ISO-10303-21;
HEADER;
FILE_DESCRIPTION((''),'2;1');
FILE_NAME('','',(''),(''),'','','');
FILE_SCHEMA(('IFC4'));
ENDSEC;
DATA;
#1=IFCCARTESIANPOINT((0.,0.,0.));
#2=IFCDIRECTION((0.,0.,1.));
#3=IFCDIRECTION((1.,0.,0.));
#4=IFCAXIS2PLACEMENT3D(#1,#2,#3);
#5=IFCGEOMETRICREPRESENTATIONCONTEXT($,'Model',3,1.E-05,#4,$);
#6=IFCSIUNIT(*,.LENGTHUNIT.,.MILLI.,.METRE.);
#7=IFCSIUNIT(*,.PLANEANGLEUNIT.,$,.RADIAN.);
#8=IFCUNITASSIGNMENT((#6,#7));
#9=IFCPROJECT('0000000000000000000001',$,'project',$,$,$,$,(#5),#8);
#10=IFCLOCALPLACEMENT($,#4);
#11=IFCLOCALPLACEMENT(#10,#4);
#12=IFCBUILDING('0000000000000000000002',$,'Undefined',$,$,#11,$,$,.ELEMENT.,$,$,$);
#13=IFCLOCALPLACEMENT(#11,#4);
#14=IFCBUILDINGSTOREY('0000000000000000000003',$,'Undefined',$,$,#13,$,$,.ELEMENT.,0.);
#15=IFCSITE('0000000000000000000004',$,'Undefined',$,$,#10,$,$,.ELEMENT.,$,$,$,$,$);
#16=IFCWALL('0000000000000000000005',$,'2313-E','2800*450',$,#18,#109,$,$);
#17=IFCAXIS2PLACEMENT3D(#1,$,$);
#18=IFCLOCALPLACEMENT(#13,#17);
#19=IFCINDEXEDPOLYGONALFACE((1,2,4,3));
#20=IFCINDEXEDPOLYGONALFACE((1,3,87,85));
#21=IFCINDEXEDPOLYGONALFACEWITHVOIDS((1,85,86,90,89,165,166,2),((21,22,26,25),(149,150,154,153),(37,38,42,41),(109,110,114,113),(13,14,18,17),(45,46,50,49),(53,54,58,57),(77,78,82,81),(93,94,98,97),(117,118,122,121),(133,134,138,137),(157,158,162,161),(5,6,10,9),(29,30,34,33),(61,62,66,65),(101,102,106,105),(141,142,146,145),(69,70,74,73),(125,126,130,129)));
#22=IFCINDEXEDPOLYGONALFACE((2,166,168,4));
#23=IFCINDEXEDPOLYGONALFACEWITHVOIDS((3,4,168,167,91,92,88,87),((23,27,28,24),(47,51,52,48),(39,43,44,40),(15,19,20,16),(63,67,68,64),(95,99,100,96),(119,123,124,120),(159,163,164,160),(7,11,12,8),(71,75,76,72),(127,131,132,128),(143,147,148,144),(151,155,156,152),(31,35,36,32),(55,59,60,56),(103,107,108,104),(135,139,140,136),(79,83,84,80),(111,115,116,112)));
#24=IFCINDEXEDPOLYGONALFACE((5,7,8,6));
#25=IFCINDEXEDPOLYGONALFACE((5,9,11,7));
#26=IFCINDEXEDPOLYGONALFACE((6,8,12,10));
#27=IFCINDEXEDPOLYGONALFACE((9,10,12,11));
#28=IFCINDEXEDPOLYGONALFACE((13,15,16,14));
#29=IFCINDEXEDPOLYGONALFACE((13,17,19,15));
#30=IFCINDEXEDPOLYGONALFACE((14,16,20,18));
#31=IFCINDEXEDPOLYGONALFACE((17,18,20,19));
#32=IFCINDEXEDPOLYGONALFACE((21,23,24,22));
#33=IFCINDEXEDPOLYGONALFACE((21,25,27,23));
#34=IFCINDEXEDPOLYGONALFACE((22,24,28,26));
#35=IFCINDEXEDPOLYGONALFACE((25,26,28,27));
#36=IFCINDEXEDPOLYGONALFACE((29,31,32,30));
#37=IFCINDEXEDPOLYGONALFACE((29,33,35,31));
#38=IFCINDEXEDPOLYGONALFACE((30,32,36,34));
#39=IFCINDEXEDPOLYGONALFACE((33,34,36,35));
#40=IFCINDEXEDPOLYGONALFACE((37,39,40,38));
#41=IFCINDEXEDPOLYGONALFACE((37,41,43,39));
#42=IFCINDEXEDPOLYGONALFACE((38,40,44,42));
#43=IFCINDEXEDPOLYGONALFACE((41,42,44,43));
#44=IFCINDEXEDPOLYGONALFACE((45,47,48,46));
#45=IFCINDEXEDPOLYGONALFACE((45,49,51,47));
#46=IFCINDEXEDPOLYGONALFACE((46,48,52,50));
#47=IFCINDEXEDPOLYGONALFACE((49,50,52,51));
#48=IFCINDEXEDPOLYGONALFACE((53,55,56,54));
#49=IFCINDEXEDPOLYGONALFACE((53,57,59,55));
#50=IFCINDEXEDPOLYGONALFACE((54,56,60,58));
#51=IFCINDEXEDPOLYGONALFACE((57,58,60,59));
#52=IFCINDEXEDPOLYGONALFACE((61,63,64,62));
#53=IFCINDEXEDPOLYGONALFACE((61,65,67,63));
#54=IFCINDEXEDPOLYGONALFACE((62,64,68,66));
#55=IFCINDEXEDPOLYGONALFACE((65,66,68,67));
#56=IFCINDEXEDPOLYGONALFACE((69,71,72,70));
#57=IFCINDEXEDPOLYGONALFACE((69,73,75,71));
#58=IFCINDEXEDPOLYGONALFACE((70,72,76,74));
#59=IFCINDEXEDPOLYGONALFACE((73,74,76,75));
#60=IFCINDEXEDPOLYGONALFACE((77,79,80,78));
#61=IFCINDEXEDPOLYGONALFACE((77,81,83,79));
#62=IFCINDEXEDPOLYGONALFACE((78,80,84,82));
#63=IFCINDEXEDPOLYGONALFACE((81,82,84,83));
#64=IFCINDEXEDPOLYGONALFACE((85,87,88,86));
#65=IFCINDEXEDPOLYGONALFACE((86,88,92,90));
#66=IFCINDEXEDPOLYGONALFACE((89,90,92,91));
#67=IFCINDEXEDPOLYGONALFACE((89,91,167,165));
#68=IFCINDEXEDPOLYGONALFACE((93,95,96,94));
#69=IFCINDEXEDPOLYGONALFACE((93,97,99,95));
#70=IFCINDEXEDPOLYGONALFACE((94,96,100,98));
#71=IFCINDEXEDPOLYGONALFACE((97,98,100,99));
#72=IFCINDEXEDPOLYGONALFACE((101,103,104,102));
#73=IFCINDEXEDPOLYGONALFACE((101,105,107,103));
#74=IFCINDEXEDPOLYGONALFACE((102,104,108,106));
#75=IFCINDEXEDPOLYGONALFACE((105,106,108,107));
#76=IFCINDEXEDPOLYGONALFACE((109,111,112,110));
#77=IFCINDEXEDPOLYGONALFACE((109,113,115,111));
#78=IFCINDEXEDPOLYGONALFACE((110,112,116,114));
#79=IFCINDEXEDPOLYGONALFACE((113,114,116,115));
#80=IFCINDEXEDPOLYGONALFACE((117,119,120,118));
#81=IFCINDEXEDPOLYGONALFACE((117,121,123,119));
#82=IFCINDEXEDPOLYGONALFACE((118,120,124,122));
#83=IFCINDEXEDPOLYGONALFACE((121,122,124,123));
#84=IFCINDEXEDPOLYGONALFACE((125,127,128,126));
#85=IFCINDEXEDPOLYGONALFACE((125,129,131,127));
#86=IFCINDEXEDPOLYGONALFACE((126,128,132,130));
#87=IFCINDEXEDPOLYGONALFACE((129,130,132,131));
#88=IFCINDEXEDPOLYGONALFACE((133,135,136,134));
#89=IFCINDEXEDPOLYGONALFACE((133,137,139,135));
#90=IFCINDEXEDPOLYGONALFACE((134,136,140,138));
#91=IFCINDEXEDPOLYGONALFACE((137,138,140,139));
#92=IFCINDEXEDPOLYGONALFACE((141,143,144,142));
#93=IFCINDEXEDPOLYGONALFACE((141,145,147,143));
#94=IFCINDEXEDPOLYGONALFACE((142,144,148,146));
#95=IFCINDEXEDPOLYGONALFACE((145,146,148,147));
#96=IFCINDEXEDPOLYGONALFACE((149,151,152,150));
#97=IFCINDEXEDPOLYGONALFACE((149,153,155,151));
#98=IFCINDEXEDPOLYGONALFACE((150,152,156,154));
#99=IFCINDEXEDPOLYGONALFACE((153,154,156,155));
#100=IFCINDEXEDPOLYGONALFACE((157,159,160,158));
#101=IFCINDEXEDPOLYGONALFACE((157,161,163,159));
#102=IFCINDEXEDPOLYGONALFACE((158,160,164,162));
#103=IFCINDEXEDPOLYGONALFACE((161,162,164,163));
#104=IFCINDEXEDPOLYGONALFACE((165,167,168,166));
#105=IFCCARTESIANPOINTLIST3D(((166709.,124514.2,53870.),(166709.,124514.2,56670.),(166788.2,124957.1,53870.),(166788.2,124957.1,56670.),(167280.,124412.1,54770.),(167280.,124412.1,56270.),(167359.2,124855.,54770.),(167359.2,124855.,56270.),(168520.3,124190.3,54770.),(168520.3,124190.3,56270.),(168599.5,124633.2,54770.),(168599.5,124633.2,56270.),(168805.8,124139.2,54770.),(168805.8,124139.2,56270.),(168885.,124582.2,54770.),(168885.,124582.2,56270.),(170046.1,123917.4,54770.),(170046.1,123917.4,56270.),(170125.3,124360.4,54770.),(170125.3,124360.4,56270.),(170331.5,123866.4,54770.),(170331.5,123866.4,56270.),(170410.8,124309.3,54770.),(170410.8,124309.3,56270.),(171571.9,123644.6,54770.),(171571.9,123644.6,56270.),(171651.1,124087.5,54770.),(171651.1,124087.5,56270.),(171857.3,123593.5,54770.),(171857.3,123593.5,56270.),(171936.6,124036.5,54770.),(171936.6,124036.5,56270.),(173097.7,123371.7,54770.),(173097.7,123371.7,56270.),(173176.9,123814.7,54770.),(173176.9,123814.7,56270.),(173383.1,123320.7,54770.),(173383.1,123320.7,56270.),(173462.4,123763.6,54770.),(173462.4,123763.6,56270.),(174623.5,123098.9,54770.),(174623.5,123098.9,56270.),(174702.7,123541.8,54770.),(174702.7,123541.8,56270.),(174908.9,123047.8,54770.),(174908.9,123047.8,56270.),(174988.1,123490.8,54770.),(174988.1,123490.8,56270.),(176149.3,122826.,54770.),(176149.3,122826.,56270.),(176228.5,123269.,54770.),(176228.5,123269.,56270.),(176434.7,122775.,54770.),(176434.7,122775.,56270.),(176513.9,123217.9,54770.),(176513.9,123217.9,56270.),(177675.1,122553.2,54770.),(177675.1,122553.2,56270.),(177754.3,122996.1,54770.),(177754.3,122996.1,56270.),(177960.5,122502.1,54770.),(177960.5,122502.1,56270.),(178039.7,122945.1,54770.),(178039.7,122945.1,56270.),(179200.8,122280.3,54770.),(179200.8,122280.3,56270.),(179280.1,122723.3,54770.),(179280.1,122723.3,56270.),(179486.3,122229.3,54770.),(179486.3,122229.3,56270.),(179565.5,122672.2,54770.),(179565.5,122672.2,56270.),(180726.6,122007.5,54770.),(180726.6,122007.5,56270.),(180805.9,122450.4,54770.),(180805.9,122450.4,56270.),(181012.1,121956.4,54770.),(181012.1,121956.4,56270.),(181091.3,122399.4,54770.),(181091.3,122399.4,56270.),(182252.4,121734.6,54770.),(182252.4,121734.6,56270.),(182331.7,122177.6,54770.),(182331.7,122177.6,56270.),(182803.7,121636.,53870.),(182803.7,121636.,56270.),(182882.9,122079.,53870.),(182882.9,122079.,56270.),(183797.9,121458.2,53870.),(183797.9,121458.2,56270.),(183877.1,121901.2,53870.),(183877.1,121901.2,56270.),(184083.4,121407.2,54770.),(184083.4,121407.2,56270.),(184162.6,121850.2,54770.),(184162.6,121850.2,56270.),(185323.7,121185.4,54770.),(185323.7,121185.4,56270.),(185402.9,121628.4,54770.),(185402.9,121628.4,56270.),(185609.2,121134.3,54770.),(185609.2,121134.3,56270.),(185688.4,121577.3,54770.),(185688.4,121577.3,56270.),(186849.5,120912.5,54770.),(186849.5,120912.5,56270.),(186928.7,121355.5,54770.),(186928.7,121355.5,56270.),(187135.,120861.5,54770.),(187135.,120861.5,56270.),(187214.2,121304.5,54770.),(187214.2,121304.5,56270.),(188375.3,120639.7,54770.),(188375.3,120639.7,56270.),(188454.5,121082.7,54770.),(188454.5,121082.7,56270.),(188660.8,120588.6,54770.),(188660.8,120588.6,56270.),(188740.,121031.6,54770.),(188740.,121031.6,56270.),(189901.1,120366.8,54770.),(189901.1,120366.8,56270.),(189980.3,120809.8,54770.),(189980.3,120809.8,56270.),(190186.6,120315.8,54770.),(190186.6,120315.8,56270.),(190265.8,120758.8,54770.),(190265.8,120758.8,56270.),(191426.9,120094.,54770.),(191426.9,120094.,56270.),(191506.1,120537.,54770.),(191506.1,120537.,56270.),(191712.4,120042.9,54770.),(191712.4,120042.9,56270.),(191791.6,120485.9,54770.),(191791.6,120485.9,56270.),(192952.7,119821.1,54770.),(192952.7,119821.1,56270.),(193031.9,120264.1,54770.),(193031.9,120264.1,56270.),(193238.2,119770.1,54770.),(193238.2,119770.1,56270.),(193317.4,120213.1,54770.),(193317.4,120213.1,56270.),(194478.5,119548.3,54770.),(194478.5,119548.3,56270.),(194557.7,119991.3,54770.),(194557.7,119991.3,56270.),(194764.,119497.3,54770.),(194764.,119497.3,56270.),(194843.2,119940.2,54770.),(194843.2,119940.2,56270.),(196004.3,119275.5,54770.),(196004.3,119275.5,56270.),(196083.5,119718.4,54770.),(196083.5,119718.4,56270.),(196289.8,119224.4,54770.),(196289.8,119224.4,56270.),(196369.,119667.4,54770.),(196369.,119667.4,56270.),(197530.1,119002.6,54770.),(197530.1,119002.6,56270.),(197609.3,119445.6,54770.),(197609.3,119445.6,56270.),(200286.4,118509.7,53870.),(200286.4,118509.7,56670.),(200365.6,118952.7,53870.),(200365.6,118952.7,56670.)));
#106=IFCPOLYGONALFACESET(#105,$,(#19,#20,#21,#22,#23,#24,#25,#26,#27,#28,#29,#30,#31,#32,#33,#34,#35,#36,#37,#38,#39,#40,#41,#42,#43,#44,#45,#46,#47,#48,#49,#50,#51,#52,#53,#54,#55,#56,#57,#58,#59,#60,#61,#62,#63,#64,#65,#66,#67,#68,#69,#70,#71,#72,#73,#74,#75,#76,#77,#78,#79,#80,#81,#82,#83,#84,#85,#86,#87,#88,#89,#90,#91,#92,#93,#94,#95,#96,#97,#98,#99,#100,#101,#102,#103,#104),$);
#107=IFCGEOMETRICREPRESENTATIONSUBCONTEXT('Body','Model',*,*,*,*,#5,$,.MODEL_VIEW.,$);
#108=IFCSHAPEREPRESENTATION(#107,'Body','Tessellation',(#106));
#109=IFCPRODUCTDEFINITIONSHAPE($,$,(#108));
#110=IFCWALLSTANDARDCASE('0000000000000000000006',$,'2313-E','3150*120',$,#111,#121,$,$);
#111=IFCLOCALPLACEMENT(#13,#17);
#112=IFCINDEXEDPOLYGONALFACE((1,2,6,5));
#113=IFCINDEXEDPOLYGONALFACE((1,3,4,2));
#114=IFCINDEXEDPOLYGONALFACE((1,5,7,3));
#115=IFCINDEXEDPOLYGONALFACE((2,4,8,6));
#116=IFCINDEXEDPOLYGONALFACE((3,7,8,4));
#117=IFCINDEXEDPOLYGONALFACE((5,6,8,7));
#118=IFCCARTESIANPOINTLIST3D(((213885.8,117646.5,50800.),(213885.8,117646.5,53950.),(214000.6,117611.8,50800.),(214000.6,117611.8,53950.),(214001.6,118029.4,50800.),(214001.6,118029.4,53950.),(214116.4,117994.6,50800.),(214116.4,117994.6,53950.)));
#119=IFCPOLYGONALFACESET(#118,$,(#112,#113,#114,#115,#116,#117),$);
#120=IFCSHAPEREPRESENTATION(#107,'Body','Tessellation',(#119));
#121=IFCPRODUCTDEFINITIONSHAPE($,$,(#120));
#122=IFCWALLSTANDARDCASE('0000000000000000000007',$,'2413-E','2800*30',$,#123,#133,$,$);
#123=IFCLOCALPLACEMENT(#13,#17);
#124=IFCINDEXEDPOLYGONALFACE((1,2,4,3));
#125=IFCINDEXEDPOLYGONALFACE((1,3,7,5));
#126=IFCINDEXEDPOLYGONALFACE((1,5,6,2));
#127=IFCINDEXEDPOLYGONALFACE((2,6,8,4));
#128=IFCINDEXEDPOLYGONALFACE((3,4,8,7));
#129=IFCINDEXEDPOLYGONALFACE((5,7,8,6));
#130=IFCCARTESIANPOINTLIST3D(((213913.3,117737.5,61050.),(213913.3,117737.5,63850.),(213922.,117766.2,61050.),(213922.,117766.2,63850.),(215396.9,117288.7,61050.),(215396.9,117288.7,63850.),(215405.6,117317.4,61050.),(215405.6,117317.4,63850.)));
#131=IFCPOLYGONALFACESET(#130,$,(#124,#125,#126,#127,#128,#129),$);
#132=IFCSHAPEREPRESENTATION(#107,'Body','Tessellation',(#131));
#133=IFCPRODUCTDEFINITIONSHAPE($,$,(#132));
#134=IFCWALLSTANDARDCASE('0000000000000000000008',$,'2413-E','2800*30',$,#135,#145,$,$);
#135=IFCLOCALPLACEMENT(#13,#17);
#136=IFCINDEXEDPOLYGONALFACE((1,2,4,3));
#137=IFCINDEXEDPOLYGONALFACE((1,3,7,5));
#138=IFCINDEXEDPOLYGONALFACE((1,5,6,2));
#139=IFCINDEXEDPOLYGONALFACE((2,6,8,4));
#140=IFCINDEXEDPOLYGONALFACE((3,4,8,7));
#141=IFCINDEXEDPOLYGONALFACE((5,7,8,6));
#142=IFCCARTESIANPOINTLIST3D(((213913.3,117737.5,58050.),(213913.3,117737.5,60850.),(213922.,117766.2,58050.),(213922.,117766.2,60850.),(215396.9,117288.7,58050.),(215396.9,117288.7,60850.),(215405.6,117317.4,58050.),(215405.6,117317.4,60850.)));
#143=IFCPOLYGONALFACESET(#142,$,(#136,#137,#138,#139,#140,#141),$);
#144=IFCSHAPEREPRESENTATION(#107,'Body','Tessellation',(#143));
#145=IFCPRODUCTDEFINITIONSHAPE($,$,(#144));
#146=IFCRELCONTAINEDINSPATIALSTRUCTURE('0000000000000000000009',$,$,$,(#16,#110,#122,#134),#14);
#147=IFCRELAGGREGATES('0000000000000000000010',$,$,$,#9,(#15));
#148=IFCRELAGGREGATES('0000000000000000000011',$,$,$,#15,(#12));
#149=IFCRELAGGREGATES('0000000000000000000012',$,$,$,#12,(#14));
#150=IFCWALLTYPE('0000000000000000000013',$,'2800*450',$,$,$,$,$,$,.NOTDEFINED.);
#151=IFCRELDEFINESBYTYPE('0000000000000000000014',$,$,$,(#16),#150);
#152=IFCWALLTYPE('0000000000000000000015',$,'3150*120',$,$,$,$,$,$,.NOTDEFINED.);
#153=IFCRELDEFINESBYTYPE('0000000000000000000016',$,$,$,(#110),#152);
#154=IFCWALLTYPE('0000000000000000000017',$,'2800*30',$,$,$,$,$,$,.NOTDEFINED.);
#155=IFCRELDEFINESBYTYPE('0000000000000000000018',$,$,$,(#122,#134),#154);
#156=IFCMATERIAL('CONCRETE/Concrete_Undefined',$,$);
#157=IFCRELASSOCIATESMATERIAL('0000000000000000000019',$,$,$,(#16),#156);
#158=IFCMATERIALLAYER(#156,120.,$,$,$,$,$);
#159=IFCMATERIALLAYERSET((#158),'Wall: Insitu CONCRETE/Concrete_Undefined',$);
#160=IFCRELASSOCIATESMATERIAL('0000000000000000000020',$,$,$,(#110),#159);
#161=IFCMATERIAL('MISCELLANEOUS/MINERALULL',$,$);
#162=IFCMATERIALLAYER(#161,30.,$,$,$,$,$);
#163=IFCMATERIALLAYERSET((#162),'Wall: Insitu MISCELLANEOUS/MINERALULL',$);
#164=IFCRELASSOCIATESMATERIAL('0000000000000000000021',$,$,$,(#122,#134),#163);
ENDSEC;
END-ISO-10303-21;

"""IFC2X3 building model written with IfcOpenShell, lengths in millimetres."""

from ifc_helpers import new_model, si_unit, frame, frame_2d, origin_with_axes, place, context, subcontext, project, spatial, rectangle, extrude, boolean, material, layer, layer_set, layer_usage, type_object, element, save


model = new_model("IFC2X3")

# Units and contexts
model_context = context("Model", 3, precision=1e-05, world=origin_with_axes())
body_context = subcontext(model_context, "Body", "Model", "MODEL_VIEW")
ifc_project = project(units=[si_unit("LENGTHUNIT", "METRE", prefix="MILLI"), si_unit("PLANEANGLEUNIT", "RADIAN")], contexts=[model_context])

# Site, building, storey
site_placement = place(None, origin_with_axes())
site = spatial("IfcSite", under=ifc_project, at=site_placement, Name="Undefined", CompositionType="ELEMENT")
building_placement = place(site_placement, origin_with_axes())
building = spatial("IfcBuilding", under=site, at=building_placement, Name="Undefined", CompositionType="ELEMENT")
storey_placement = place(building_placement, origin_with_axes())
storey = spatial("IfcBuildingStorey", under=building, at=storey_placement, Name="Undefined", CompositionType="ELEMENT", Elevation=0.0)

# Shared definitions
ifc_material_1 = material(Name="CONCRETE/Concrete_Undefined")

# Walls
wall_type_1 = type_object("IfcWallType", Name="2800*450", PredefinedType="NOTDEFINED")
wall_1_placement = place(storey_placement, frame((200326.0, 118731.2, 53870.0), z_axis=(0.0, 0.0, 1.0), x_axis=(-0.984385, 0.176032, 0.0)))
solid_1 = boolean("DIFFERENCE", boolean("DIFFERENCE", boolean("DIFFERENCE", boolean("DIFFERENCE", boolean("DIFFERENCE", boolean("DIFFERENCE", boolean("DIFFERENCE", boolean("DIFFERENCE", extrude(rectangle(XDim=34110.0, YDim=450.0, at=frame_2d((0.0, 17055.0), x_axis=(0.0, -1.0))), frame((0.0, 0.0, 0.0), z_axis=(0.0, 0.0, 1.0), x_axis=(0.0, -1.0, 0.0)), (0.0, 0.0, 1.0), 2800.0), extrude(rectangle(XDim=1260.0, YDim=450.0, at=frame_2d((0.0, 630.0), x_axis=(0.0, -1.0))), frame((33530.0, 0.0, 900.0), z_axis=(0.0, 0.0, 1.0), x_axis=(0.0, 1.0, 0.0)), (0.0, 0.0, 1.0), 1500.0)), extrude(rectangle(XDim=1260.0, YDim=450.0, at=frame_2d((0.0, 630.0), x_axis=(0.0, -1.0))), frame((31980.0, 0.0, 900.0), z_axis=(0.0, 0.0, 1.0), x_axis=(0.0, 1.0, 0.0)), (0.0, 0.0, 1.0), 1500.0)), extrude(rectangle(XDim=1260.0, YDim=450.0, at=frame_2d((0.0, 630.0), x_axis=(0.0, -1.0))), frame((19580.0, 0.0, 900.0), z_axis=(0.0, 0.0, 1.0), x_axis=(0.0, 1.0, 0.0)), (0.0, 0.0, 1.0), 1500.0)), extrude(rectangle(XDim=1260.0, YDim=450.0, at=frame_2d((0.0, 630.0), x_axis=(0.0, -1.0))), frame((21130.0, 0.0, 900.0), z_axis=(0.0, 0.0, 1.0), x_axis=(0.0, 1.0, 0.0)), (0.0, 0.0, 1.0), 1500.0)), extrude(rectangle(XDim=1260.0, YDim=450.0, at=frame_2d((0.0, 630.0), x_axis=(0.0, -1.0))), frame((22680.0, 0.0, 900.0), z_axis=(0.0, 0.0, 1.0), x_axis=(0.0, 1.0, 0.0)), (0.0, 0.0, 1.0), 1500.0)), extrude(rectangle(XDim=1260.0, YDim=450.0, at=frame_2d((0.0, 630.0), x_axis=(0.0, -1.0))), frame((24230.0, 0.0, 900.0), z_axis=(0.0, 0.0, 1.0), x_axis=(0.0, 1.0, 0.0)), (0.0, 0.0, 1.0), 1500.0)), extrude(rectangle(XDim=1260.0, YDim=450.0, at=frame_2d((0.0, 630.0), x_axis=(0.0, -1.0))), frame((25780.0, 0.0, 900.0), z_axis=(0.0, 0.0, 1.0), x_axis=(0.0, 1.0, 0.0)), (0.0, 0.0, 1.0), 1500.0)), extrude(rectangle(XDim=1260.0, YDim=450.0, at=frame_2d((0.0, 630.0), x_axis=(0.0, -1.0))), frame((27330.0, 0.0, 900.0), z_axis=(0.0, 0.0, 1.0), x_axis=(0.0, 1.0, 0.0)), (0.0, 0.0, 1.0), 1500.0))
solid_2 = boolean("DIFFERENCE", boolean("DIFFERENCE", boolean("DIFFERENCE", boolean("DIFFERENCE", boolean("DIFFERENCE", boolean("DIFFERENCE", boolean("DIFFERENCE", boolean("DIFFERENCE", solid_1, extrude(rectangle(XDim=1260.0, YDim=450.0, at=frame_2d((0.0, 630.0), x_axis=(0.0, -1.0))), frame((28880.0, 0.0, 900.0), z_axis=(0.0, 0.0, 1.0), x_axis=(0.0, 1.0, 0.0)), (0.0, 0.0, 1.0), 1500.0)), extrude(rectangle(XDim=1260.0, YDim=450.0, at=frame_2d((0.0, 630.0), x_axis=(0.0, -1.0))), frame((30430.0, 0.0, 900.0), z_axis=(0.0, 0.0, 1.0), x_axis=(0.0, 1.0, 0.0)), (0.0, 0.0, 1.0), 1500.0)), extrude(rectangle(XDim=1010.0, YDim=450.0, at=frame_2d((0.0, 505.0), x_axis=(0.0, -1.0))), frame((17760.0, 0.0, 0.0), z_axis=(0.0, 0.0, 1.0), x_axis=(0.0, 1.0, 0.0)), (0.0, 0.0, 1.0), 2400.0)), extrude(rectangle(XDim=1260.0, YDim=450.0, at=frame_2d((0.0, 630.0), x_axis=(0.0, -1.0))), frame((16460.0, 0.0, 900.0), z_axis=(0.0, 0.0, 1.0), x_axis=(0.0, 1.0, 0.0)), (0.0, 0.0, 1.0), 1500.0)), extrude(rectangle(XDim=1260.0, YDim=450.0, at=frame_2d((0.0, 630.0), x_axis=(0.0, -1.0))), frame((4060.0, 0.0, 900.0), z_axis=(0.0, 0.0, 1.0), x_axis=(0.0, 1.0, 0.0)), (0.0, 0.0, 1.0), 1500.0)), extrude(rectangle(XDim=1260.0, YDim=450.0, at=frame_2d((0.0, 630.0), x_axis=(0.0, -1.0))), frame((5610.0, 0.0, 900.0), z_axis=(0.0, 0.0, 1.0), x_axis=(0.0, 1.0, 0.0)), (0.0, 0.0, 1.0), 1500.0)), extrude(rectangle(XDim=1260.0, YDim=450.0, at=frame_2d((0.0, 630.0), x_axis=(0.0, -1.0))), frame((7160.0, 0.0, 900.0), z_axis=(0.0, 0.0, 1.0), x_axis=(0.0, 1.0, 0.0)), (0.0, 0.0, 1.0), 1500.0)), extrude(rectangle(XDim=1260.0, YDim=450.0, at=frame_2d((0.0, 630.0), x_axis=(0.0, -1.0))), frame((8710.0, 0.0, 900.0), z_axis=(0.0, 0.0, 1.0), x_axis=(0.0, 1.0, 0.0)), (0.0, 0.0, 1.0), 1500.0))
element("IfcWall", 1, at=wall_1_placement, inside=storey, type_object=wall_type_1, material=ifc_material_1, Name="2313-E", Description="2800*450", context=body_context, shape_type="CSG", body=[
    boolean("DIFFERENCE", boolean("DIFFERENCE", boolean("DIFFERENCE", boolean("DIFFERENCE", solid_2, extrude(rectangle(XDim=1260.0, YDim=450.0, at=frame_2d((0.0, 630.0), x_axis=(0.0, -1.0))), frame((10260.0, 0.0, 900.0), z_axis=(0.0, 0.0, 1.0), x_axis=(0.0, 1.0, 0.0)), (0.0, 0.0, 1.0), 1500.0)), extrude(rectangle(XDim=1260.0, YDim=450.0, at=frame_2d((0.0, 630.0), x_axis=(0.0, -1.0))), frame((11810.0, 0.0, 900.0), z_axis=(0.0, 0.0, 1.0), x_axis=(0.0, 1.0, 0.0)), (0.0, 0.0, 1.0), 1500.0)), extrude(rectangle(XDim=1260.0, YDim=450.0, at=frame_2d((0.0, 630.0), x_axis=(0.0, -1.0))), frame((13360.0, 0.0, 900.0), z_axis=(0.0, 0.0, 1.0), x_axis=(0.0, 1.0, 0.0)), (0.0, 0.0, 1.0), 1500.0)), extrude(rectangle(XDim=1260.0, YDim=450.0, at=frame_2d((0.0, 630.0), x_axis=(0.0, -1.0))), frame((14910.0, 0.0, 900.0), z_axis=(0.0, 0.0, 1.0), x_axis=(0.0, 1.0, 0.0)), (0.0, 0.0, 1.0), 1500.0)),
])
ifc_layer_1 = layer(ifc_material_1, 120.0)
ifc_layer_set_1 = layer_set([ifc_layer_1], Name="Wall: Insitu CONCRETE/Concrete_Undefined")
ifc_layer_usage_1 = layer_usage(ifc_layer_set_1, "AXIS2", "POSITIVE", -60.0)
wall_type_2 = type_object("IfcWallType", Name="3150*120", PredefinedType="NOTDEFINED")
wall_2_placement = place(storey_placement, frame((214059.0, 118012.0, 50800.0), z_axis=(0.0, 0.0, 1.0), x_axis=(-0.289533, -0.957168, 0.0)))
element("IfcWallStandardCase", 2, at=wall_2_placement, inside=storey, type_object=wall_type_2, material=ifc_layer_usage_1, Name="2313-E", Description="3150*120", context=body_context, shape_type="SweptSolid", body=[
    extrude(rectangle(XDim=400.0, YDim=120.0, at=frame_2d((0.0, 200.0), x_axis=(0.0, -1.0))), frame((0.0, 0.0, 0.0), z_axis=(0.0, 0.0, 1.0), x_axis=(0.0, -1.0, 0.0)), (0.0, 0.0, 1.0), 3150.0),
])
ifc_material_2 = material(Name="MISCELLANEOUS/MINERALULL")
ifc_layer_2 = layer(ifc_material_2, 30.0)
ifc_layer_set_2 = layer_set([ifc_layer_2], Name="Wall: Insitu MISCELLANEOUS/MINERALULL")
ifc_layer_usage_2 = layer_usage(ifc_layer_set_2, "AXIS2", "POSITIVE", -15.0)
wall_type_3 = type_object("IfcWallType", Name="2800*30", PredefinedType="NOTDEFINED")
wall_3_placement = place(storey_placement, frame((213917.6, 117751.8, 61050.0), z_axis=(0.0, 0.0, 1.0), x_axis=(0.957168, -0.289533, 0.0)))
element("IfcWallStandardCase", 3, at=wall_3_placement, inside=storey, type_object=wall_type_3, material=ifc_layer_usage_2, Name="2413-E", Description="2800*30", context=body_context, shape_type="SweptSolid", body=[
    extrude(rectangle(XDim=1550.0, YDim=30.0, at=frame_2d((0.0, 775.0), x_axis=(0.0, -1.0))), frame((0.0, 0.0, 0.0), z_axis=(0.0, 0.0, 1.0), x_axis=(0.0, -1.0, 0.0)), (0.0, 0.0, 1.0), 2800.0),
])
ifc_layer_usage_3 = layer_usage(ifc_layer_set_2, "AXIS2", "POSITIVE", -15.0)
wall_4_placement = place(storey_placement, frame((213917.6, 117751.8, 58050.0), z_axis=(0.0, 0.0, 1.0), x_axis=(0.957168, -0.289533, 0.0)))
element("IfcWallStandardCase", 4, at=wall_4_placement, inside=storey, type_object=wall_type_3, material=ifc_layer_usage_3, Name="2413-E", Description="2800*30", context=body_context, shape_type="SweptSolid", body=[
    extrude(rectangle(XDim=1550.0, YDim=30.0, at=frame_2d((0.0, 775.0), x_axis=(0.0, -1.0))), frame((0.0, 0.0, 0.0), z_axis=(0.0, 0.0, 1.0), x_axis=(0.0, -1.0, 0.0)), (0.0, 0.0, 1.0), 2800.0),
])

save(model, "model.ifc")
